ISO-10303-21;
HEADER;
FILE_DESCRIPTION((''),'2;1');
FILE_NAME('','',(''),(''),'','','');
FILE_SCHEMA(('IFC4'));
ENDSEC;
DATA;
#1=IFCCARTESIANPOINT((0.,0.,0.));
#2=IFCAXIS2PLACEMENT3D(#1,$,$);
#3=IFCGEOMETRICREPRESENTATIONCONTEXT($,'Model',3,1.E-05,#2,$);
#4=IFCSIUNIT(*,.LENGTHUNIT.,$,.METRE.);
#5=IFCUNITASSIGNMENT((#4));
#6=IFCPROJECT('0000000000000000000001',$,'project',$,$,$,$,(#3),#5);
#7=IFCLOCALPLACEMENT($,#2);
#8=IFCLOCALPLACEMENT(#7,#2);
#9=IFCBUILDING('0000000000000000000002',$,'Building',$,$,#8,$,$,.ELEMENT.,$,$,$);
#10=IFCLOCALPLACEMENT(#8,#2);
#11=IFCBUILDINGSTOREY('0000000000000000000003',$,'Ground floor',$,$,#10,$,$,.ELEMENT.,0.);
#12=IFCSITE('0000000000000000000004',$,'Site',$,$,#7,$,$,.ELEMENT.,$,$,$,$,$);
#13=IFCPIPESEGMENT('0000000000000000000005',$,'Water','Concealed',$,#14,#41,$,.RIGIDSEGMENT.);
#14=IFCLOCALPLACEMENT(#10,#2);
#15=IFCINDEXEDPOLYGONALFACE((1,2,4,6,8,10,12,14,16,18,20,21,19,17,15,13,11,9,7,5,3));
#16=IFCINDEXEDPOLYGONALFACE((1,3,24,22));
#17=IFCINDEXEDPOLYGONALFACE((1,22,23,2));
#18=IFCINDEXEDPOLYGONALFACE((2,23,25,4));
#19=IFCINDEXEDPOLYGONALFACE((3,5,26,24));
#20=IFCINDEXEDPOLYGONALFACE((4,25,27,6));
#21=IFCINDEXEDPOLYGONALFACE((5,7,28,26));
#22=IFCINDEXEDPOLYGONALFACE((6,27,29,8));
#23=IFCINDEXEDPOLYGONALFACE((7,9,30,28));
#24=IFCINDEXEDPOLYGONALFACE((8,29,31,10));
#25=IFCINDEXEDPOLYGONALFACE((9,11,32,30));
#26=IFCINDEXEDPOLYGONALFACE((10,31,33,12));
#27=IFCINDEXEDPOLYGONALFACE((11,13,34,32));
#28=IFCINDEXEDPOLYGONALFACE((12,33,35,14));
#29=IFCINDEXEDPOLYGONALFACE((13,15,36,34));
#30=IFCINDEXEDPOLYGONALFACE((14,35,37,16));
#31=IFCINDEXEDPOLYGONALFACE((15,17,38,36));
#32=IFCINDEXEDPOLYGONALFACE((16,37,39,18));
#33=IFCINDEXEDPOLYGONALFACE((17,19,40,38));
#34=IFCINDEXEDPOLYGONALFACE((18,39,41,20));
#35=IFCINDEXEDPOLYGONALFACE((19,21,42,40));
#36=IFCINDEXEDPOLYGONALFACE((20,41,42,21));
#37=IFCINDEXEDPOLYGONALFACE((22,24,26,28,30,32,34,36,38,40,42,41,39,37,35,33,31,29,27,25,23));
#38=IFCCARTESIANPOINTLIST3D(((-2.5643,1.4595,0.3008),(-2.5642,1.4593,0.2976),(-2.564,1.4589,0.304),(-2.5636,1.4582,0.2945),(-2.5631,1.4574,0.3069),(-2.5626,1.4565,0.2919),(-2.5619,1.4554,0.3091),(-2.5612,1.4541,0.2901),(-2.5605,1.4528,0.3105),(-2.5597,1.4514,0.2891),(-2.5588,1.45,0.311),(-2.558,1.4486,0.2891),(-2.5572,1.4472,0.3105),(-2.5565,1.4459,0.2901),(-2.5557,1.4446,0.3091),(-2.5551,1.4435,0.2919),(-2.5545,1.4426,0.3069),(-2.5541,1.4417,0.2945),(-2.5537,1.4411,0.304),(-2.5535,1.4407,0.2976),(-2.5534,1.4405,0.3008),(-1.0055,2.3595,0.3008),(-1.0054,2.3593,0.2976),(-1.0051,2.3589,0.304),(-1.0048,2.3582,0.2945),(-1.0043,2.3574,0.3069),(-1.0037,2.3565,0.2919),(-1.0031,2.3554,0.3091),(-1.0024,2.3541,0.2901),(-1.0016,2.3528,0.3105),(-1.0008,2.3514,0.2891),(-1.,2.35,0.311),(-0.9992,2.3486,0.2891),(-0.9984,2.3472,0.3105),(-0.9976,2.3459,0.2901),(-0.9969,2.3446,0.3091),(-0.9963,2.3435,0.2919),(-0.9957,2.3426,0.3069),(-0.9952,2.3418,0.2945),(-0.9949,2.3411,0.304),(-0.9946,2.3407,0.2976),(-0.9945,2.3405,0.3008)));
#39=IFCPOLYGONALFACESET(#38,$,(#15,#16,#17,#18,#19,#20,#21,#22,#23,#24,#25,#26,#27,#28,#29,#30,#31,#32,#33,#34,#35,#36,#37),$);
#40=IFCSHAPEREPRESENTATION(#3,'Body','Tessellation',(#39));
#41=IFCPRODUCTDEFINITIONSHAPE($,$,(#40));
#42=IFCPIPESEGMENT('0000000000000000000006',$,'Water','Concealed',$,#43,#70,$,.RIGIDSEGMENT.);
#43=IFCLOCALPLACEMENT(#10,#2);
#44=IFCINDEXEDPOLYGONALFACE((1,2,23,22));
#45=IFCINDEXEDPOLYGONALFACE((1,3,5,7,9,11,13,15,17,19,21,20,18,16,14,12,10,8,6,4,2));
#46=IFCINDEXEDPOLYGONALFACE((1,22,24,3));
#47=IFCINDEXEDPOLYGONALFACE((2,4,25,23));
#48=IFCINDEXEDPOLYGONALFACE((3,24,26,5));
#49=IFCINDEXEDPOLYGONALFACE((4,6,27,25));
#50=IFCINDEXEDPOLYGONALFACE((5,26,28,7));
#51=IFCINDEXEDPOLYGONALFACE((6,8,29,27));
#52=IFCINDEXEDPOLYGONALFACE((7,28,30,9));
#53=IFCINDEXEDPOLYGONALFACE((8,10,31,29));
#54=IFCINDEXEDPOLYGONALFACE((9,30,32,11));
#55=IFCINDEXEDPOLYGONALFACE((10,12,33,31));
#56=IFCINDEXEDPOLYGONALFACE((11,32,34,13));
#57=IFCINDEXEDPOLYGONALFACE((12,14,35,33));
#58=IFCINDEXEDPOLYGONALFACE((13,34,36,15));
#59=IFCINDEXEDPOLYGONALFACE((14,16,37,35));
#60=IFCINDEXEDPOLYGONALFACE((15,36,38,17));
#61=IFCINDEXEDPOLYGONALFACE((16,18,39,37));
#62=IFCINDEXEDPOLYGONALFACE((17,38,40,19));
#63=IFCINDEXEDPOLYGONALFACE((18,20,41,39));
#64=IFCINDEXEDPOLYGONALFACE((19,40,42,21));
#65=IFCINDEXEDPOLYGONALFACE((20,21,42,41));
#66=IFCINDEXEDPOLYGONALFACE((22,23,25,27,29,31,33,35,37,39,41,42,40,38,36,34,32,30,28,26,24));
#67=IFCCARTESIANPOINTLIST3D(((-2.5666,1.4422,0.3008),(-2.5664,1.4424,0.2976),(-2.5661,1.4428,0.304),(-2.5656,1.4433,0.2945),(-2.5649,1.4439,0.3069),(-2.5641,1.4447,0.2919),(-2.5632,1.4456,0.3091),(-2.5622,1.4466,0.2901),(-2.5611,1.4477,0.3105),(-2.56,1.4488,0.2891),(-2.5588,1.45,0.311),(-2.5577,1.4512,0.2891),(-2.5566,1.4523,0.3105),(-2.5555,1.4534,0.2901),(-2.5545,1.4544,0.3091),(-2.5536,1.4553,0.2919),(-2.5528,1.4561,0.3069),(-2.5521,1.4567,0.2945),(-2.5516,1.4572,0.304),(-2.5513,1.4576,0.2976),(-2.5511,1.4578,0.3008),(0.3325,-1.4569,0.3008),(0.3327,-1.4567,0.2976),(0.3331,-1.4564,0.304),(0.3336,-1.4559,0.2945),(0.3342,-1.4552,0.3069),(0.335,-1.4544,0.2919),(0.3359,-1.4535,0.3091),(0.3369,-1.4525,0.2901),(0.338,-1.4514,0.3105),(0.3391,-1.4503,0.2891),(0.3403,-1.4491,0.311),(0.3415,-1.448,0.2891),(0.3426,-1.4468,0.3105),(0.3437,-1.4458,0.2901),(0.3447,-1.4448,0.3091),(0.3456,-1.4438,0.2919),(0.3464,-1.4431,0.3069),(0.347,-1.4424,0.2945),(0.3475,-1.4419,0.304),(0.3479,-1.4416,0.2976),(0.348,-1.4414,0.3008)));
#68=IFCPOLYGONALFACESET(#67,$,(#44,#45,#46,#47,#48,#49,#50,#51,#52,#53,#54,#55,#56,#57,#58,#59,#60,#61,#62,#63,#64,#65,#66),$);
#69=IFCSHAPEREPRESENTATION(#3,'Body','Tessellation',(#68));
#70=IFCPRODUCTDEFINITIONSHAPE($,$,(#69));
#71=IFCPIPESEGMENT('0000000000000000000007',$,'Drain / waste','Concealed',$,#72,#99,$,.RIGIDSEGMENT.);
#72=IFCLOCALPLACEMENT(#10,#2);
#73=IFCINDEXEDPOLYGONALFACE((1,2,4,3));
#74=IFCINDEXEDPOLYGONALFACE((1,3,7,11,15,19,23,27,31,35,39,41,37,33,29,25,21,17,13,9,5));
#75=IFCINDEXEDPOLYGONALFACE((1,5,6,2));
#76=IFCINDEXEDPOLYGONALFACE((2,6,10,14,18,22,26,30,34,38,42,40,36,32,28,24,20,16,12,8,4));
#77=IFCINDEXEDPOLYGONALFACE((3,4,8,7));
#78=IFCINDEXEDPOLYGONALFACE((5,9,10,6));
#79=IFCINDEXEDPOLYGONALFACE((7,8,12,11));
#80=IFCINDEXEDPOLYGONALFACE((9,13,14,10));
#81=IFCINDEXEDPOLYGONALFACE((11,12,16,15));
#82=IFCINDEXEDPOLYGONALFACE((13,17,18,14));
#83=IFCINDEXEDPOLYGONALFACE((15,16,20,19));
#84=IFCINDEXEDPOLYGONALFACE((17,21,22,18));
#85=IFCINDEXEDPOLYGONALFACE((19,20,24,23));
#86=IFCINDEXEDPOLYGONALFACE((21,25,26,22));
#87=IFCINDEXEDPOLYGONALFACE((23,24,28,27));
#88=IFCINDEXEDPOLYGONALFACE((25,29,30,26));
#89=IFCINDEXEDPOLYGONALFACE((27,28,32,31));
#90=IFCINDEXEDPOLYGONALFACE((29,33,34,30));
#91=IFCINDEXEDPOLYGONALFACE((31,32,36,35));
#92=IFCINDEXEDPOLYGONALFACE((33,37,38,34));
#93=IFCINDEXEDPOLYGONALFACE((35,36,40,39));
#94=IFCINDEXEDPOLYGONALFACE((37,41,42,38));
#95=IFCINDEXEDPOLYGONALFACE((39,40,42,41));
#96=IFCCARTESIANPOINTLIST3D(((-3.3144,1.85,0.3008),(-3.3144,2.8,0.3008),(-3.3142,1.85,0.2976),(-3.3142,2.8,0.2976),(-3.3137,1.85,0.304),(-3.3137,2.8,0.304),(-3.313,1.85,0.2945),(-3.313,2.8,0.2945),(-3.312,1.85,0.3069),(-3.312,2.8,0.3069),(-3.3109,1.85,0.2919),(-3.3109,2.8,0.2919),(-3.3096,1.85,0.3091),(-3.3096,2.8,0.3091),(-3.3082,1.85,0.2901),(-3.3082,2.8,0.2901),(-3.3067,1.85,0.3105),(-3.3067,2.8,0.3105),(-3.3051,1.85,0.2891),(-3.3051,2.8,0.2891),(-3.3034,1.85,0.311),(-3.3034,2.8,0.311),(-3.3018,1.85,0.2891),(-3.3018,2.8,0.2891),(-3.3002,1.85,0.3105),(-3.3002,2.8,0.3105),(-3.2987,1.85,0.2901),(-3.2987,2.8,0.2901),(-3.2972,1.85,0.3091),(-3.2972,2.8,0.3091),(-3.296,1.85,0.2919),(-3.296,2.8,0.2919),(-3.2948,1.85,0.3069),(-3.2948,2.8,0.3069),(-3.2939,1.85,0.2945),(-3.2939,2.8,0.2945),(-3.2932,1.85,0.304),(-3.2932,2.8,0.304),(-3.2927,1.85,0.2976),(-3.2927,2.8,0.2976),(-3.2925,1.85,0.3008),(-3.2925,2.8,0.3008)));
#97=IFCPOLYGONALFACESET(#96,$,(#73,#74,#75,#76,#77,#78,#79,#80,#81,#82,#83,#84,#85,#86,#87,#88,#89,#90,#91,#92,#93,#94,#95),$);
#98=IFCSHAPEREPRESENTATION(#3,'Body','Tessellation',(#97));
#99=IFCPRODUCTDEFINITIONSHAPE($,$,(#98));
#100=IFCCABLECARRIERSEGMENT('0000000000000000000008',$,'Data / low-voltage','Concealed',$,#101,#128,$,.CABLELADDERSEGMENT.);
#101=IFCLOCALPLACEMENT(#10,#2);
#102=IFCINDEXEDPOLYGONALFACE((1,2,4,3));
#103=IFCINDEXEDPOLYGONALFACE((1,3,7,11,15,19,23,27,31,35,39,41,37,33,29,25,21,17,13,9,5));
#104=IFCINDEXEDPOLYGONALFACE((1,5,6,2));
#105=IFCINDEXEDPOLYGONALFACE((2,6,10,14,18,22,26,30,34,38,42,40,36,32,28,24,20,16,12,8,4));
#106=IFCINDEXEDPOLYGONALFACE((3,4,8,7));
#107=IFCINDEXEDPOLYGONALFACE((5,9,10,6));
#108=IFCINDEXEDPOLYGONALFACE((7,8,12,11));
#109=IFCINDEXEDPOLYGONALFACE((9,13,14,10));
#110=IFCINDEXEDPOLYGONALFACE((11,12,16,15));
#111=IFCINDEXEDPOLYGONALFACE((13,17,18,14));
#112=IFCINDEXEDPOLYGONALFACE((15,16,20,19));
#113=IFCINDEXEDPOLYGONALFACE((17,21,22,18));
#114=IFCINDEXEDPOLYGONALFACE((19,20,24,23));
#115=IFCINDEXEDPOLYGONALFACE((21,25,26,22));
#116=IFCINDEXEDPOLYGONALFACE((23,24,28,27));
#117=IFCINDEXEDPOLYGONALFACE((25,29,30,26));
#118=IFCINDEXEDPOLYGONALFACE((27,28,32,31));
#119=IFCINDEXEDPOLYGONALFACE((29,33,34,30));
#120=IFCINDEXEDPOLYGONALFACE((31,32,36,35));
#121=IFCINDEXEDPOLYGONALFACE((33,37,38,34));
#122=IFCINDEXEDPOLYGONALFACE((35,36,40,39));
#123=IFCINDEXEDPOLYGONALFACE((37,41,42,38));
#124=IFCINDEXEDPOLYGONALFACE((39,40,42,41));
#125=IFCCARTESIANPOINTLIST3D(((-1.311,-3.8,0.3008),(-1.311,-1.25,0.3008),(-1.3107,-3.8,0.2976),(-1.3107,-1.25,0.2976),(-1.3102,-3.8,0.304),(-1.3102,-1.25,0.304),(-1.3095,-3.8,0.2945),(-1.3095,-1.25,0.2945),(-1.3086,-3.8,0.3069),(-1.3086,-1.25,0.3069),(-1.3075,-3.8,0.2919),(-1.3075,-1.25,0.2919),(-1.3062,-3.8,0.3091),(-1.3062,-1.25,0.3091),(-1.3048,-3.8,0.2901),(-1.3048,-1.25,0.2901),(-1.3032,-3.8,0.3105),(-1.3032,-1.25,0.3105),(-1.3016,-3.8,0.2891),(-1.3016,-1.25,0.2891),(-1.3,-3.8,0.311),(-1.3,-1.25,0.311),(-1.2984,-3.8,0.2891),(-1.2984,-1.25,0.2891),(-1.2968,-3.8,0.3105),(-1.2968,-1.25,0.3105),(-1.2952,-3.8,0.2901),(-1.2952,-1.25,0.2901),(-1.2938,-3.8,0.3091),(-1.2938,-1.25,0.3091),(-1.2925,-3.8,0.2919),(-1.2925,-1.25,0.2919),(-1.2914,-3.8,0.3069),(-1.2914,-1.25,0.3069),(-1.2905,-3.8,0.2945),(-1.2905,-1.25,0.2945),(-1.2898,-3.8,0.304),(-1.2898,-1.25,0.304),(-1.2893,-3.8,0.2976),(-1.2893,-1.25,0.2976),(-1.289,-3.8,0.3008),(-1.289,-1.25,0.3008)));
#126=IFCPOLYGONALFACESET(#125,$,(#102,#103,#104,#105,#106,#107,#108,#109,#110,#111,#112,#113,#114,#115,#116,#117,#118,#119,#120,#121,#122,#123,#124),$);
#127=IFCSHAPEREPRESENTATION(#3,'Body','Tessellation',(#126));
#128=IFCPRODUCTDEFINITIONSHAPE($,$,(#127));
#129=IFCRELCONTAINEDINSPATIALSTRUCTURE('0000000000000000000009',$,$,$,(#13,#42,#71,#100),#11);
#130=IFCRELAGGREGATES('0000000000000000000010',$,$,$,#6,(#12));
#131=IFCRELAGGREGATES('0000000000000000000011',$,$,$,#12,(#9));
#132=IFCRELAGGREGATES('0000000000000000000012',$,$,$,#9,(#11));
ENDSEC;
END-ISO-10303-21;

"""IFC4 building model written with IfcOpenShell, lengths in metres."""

from ifc_helpers import new_model, si_unit, frame, origin, origin_2d, place, context, project, spatial, circle, extrude, element, save


model = new_model("IFC4")

# Units and contexts
model_context = context("Model", 3, precision=1e-05, world=origin())
ifc_project = project(units=[si_unit("LENGTHUNIT", "METRE")], contexts=[model_context])

# Site, building, storey
site_placement = place(None, origin())
site = spatial("IfcSite", under=ifc_project, at=site_placement, Name="Site", CompositionType="ELEMENT")
building_placement = place(site_placement, origin())
building = spatial("IfcBuilding", under=site, at=building_placement, Name="Building", CompositionType="ELEMENT")
storey_placement = place(building_placement, origin())
storey = spatial("IfcBuildingStorey", under=building, at=storey_placement, Name="Ground floor", CompositionType="ELEMENT", Elevation=0.0)

# Pipe segments
pipe_segment_1_placement = place(storey_placement, frame((-1.0, 2.35, 0.3), z_axis=(-0.866025, -0.5, 0.0), x_axis=(0.0, 0.0, 1.0)))
element("IfcPipeSegment", 1, at=pipe_segment_1_placement, inside=storey, Name="Water", Description="Concealed", PredefinedType="RIGIDSEGMENT", context=model_context, shape_type="SweptSolid", body=[
    extrude(circle(Radius=0.011, at=origin_2d()), origin(), (0.0, 0.0, 1.0), 1.8),
])
pipe_segment_2_placement = place(storey_placement, frame((-2.5588, 1.45, 0.3), z_axis=(0.707107, -0.707107, 0.0), x_axis=(0.0, 0.0, 1.0)))
element("IfcPipeSegment", 2, at=pipe_segment_2_placement, inside=storey, Name="Water", Description="Concealed", PredefinedType="RIGIDSEGMENT", context=model_context, shape_type="SweptSolid", body=[
    extrude(circle(Radius=0.011, at=origin_2d()), origin(), (0.0, 0.0, 1.0), 4.1),
])
pipe_segment_3_placement = place(storey_placement, frame((-3.3034, 2.8, 0.3), z_axis=(0.0, -1.0, 0.0), x_axis=(0.0, 0.0, 1.0)))
element("IfcPipeSegment", 3, at=pipe_segment_3_placement, inside=storey, Name="Drain / waste", Description="Concealed", PredefinedType="RIGIDSEGMENT", context=model_context, shape_type="SweptSolid", body=[
    extrude(circle(Radius=0.011, at=origin_2d()), origin(), (0.0, 0.0, 1.0), 0.95),
])

# Cable carrier segment
cable_carrier_segment_placement = place(storey_placement, frame((-1.3, -1.25, 0.3), z_axis=(0.0, -1.0, 0.0), x_axis=(0.0, 0.0, 1.0)))
element("IfcCableCarrierSegment", 4, at=cable_carrier_segment_placement, inside=storey, Name="Data / low-voltage", Description="Concealed", PredefinedType="CABLELADDERSEGMENT", context=model_context, shape_type="SweptSolid", body=[
    extrude(circle(Radius=0.011, at=origin_2d()), origin(), (0.0, 0.0, 1.0), 2.55),
])

save(model, "model.ifc")
